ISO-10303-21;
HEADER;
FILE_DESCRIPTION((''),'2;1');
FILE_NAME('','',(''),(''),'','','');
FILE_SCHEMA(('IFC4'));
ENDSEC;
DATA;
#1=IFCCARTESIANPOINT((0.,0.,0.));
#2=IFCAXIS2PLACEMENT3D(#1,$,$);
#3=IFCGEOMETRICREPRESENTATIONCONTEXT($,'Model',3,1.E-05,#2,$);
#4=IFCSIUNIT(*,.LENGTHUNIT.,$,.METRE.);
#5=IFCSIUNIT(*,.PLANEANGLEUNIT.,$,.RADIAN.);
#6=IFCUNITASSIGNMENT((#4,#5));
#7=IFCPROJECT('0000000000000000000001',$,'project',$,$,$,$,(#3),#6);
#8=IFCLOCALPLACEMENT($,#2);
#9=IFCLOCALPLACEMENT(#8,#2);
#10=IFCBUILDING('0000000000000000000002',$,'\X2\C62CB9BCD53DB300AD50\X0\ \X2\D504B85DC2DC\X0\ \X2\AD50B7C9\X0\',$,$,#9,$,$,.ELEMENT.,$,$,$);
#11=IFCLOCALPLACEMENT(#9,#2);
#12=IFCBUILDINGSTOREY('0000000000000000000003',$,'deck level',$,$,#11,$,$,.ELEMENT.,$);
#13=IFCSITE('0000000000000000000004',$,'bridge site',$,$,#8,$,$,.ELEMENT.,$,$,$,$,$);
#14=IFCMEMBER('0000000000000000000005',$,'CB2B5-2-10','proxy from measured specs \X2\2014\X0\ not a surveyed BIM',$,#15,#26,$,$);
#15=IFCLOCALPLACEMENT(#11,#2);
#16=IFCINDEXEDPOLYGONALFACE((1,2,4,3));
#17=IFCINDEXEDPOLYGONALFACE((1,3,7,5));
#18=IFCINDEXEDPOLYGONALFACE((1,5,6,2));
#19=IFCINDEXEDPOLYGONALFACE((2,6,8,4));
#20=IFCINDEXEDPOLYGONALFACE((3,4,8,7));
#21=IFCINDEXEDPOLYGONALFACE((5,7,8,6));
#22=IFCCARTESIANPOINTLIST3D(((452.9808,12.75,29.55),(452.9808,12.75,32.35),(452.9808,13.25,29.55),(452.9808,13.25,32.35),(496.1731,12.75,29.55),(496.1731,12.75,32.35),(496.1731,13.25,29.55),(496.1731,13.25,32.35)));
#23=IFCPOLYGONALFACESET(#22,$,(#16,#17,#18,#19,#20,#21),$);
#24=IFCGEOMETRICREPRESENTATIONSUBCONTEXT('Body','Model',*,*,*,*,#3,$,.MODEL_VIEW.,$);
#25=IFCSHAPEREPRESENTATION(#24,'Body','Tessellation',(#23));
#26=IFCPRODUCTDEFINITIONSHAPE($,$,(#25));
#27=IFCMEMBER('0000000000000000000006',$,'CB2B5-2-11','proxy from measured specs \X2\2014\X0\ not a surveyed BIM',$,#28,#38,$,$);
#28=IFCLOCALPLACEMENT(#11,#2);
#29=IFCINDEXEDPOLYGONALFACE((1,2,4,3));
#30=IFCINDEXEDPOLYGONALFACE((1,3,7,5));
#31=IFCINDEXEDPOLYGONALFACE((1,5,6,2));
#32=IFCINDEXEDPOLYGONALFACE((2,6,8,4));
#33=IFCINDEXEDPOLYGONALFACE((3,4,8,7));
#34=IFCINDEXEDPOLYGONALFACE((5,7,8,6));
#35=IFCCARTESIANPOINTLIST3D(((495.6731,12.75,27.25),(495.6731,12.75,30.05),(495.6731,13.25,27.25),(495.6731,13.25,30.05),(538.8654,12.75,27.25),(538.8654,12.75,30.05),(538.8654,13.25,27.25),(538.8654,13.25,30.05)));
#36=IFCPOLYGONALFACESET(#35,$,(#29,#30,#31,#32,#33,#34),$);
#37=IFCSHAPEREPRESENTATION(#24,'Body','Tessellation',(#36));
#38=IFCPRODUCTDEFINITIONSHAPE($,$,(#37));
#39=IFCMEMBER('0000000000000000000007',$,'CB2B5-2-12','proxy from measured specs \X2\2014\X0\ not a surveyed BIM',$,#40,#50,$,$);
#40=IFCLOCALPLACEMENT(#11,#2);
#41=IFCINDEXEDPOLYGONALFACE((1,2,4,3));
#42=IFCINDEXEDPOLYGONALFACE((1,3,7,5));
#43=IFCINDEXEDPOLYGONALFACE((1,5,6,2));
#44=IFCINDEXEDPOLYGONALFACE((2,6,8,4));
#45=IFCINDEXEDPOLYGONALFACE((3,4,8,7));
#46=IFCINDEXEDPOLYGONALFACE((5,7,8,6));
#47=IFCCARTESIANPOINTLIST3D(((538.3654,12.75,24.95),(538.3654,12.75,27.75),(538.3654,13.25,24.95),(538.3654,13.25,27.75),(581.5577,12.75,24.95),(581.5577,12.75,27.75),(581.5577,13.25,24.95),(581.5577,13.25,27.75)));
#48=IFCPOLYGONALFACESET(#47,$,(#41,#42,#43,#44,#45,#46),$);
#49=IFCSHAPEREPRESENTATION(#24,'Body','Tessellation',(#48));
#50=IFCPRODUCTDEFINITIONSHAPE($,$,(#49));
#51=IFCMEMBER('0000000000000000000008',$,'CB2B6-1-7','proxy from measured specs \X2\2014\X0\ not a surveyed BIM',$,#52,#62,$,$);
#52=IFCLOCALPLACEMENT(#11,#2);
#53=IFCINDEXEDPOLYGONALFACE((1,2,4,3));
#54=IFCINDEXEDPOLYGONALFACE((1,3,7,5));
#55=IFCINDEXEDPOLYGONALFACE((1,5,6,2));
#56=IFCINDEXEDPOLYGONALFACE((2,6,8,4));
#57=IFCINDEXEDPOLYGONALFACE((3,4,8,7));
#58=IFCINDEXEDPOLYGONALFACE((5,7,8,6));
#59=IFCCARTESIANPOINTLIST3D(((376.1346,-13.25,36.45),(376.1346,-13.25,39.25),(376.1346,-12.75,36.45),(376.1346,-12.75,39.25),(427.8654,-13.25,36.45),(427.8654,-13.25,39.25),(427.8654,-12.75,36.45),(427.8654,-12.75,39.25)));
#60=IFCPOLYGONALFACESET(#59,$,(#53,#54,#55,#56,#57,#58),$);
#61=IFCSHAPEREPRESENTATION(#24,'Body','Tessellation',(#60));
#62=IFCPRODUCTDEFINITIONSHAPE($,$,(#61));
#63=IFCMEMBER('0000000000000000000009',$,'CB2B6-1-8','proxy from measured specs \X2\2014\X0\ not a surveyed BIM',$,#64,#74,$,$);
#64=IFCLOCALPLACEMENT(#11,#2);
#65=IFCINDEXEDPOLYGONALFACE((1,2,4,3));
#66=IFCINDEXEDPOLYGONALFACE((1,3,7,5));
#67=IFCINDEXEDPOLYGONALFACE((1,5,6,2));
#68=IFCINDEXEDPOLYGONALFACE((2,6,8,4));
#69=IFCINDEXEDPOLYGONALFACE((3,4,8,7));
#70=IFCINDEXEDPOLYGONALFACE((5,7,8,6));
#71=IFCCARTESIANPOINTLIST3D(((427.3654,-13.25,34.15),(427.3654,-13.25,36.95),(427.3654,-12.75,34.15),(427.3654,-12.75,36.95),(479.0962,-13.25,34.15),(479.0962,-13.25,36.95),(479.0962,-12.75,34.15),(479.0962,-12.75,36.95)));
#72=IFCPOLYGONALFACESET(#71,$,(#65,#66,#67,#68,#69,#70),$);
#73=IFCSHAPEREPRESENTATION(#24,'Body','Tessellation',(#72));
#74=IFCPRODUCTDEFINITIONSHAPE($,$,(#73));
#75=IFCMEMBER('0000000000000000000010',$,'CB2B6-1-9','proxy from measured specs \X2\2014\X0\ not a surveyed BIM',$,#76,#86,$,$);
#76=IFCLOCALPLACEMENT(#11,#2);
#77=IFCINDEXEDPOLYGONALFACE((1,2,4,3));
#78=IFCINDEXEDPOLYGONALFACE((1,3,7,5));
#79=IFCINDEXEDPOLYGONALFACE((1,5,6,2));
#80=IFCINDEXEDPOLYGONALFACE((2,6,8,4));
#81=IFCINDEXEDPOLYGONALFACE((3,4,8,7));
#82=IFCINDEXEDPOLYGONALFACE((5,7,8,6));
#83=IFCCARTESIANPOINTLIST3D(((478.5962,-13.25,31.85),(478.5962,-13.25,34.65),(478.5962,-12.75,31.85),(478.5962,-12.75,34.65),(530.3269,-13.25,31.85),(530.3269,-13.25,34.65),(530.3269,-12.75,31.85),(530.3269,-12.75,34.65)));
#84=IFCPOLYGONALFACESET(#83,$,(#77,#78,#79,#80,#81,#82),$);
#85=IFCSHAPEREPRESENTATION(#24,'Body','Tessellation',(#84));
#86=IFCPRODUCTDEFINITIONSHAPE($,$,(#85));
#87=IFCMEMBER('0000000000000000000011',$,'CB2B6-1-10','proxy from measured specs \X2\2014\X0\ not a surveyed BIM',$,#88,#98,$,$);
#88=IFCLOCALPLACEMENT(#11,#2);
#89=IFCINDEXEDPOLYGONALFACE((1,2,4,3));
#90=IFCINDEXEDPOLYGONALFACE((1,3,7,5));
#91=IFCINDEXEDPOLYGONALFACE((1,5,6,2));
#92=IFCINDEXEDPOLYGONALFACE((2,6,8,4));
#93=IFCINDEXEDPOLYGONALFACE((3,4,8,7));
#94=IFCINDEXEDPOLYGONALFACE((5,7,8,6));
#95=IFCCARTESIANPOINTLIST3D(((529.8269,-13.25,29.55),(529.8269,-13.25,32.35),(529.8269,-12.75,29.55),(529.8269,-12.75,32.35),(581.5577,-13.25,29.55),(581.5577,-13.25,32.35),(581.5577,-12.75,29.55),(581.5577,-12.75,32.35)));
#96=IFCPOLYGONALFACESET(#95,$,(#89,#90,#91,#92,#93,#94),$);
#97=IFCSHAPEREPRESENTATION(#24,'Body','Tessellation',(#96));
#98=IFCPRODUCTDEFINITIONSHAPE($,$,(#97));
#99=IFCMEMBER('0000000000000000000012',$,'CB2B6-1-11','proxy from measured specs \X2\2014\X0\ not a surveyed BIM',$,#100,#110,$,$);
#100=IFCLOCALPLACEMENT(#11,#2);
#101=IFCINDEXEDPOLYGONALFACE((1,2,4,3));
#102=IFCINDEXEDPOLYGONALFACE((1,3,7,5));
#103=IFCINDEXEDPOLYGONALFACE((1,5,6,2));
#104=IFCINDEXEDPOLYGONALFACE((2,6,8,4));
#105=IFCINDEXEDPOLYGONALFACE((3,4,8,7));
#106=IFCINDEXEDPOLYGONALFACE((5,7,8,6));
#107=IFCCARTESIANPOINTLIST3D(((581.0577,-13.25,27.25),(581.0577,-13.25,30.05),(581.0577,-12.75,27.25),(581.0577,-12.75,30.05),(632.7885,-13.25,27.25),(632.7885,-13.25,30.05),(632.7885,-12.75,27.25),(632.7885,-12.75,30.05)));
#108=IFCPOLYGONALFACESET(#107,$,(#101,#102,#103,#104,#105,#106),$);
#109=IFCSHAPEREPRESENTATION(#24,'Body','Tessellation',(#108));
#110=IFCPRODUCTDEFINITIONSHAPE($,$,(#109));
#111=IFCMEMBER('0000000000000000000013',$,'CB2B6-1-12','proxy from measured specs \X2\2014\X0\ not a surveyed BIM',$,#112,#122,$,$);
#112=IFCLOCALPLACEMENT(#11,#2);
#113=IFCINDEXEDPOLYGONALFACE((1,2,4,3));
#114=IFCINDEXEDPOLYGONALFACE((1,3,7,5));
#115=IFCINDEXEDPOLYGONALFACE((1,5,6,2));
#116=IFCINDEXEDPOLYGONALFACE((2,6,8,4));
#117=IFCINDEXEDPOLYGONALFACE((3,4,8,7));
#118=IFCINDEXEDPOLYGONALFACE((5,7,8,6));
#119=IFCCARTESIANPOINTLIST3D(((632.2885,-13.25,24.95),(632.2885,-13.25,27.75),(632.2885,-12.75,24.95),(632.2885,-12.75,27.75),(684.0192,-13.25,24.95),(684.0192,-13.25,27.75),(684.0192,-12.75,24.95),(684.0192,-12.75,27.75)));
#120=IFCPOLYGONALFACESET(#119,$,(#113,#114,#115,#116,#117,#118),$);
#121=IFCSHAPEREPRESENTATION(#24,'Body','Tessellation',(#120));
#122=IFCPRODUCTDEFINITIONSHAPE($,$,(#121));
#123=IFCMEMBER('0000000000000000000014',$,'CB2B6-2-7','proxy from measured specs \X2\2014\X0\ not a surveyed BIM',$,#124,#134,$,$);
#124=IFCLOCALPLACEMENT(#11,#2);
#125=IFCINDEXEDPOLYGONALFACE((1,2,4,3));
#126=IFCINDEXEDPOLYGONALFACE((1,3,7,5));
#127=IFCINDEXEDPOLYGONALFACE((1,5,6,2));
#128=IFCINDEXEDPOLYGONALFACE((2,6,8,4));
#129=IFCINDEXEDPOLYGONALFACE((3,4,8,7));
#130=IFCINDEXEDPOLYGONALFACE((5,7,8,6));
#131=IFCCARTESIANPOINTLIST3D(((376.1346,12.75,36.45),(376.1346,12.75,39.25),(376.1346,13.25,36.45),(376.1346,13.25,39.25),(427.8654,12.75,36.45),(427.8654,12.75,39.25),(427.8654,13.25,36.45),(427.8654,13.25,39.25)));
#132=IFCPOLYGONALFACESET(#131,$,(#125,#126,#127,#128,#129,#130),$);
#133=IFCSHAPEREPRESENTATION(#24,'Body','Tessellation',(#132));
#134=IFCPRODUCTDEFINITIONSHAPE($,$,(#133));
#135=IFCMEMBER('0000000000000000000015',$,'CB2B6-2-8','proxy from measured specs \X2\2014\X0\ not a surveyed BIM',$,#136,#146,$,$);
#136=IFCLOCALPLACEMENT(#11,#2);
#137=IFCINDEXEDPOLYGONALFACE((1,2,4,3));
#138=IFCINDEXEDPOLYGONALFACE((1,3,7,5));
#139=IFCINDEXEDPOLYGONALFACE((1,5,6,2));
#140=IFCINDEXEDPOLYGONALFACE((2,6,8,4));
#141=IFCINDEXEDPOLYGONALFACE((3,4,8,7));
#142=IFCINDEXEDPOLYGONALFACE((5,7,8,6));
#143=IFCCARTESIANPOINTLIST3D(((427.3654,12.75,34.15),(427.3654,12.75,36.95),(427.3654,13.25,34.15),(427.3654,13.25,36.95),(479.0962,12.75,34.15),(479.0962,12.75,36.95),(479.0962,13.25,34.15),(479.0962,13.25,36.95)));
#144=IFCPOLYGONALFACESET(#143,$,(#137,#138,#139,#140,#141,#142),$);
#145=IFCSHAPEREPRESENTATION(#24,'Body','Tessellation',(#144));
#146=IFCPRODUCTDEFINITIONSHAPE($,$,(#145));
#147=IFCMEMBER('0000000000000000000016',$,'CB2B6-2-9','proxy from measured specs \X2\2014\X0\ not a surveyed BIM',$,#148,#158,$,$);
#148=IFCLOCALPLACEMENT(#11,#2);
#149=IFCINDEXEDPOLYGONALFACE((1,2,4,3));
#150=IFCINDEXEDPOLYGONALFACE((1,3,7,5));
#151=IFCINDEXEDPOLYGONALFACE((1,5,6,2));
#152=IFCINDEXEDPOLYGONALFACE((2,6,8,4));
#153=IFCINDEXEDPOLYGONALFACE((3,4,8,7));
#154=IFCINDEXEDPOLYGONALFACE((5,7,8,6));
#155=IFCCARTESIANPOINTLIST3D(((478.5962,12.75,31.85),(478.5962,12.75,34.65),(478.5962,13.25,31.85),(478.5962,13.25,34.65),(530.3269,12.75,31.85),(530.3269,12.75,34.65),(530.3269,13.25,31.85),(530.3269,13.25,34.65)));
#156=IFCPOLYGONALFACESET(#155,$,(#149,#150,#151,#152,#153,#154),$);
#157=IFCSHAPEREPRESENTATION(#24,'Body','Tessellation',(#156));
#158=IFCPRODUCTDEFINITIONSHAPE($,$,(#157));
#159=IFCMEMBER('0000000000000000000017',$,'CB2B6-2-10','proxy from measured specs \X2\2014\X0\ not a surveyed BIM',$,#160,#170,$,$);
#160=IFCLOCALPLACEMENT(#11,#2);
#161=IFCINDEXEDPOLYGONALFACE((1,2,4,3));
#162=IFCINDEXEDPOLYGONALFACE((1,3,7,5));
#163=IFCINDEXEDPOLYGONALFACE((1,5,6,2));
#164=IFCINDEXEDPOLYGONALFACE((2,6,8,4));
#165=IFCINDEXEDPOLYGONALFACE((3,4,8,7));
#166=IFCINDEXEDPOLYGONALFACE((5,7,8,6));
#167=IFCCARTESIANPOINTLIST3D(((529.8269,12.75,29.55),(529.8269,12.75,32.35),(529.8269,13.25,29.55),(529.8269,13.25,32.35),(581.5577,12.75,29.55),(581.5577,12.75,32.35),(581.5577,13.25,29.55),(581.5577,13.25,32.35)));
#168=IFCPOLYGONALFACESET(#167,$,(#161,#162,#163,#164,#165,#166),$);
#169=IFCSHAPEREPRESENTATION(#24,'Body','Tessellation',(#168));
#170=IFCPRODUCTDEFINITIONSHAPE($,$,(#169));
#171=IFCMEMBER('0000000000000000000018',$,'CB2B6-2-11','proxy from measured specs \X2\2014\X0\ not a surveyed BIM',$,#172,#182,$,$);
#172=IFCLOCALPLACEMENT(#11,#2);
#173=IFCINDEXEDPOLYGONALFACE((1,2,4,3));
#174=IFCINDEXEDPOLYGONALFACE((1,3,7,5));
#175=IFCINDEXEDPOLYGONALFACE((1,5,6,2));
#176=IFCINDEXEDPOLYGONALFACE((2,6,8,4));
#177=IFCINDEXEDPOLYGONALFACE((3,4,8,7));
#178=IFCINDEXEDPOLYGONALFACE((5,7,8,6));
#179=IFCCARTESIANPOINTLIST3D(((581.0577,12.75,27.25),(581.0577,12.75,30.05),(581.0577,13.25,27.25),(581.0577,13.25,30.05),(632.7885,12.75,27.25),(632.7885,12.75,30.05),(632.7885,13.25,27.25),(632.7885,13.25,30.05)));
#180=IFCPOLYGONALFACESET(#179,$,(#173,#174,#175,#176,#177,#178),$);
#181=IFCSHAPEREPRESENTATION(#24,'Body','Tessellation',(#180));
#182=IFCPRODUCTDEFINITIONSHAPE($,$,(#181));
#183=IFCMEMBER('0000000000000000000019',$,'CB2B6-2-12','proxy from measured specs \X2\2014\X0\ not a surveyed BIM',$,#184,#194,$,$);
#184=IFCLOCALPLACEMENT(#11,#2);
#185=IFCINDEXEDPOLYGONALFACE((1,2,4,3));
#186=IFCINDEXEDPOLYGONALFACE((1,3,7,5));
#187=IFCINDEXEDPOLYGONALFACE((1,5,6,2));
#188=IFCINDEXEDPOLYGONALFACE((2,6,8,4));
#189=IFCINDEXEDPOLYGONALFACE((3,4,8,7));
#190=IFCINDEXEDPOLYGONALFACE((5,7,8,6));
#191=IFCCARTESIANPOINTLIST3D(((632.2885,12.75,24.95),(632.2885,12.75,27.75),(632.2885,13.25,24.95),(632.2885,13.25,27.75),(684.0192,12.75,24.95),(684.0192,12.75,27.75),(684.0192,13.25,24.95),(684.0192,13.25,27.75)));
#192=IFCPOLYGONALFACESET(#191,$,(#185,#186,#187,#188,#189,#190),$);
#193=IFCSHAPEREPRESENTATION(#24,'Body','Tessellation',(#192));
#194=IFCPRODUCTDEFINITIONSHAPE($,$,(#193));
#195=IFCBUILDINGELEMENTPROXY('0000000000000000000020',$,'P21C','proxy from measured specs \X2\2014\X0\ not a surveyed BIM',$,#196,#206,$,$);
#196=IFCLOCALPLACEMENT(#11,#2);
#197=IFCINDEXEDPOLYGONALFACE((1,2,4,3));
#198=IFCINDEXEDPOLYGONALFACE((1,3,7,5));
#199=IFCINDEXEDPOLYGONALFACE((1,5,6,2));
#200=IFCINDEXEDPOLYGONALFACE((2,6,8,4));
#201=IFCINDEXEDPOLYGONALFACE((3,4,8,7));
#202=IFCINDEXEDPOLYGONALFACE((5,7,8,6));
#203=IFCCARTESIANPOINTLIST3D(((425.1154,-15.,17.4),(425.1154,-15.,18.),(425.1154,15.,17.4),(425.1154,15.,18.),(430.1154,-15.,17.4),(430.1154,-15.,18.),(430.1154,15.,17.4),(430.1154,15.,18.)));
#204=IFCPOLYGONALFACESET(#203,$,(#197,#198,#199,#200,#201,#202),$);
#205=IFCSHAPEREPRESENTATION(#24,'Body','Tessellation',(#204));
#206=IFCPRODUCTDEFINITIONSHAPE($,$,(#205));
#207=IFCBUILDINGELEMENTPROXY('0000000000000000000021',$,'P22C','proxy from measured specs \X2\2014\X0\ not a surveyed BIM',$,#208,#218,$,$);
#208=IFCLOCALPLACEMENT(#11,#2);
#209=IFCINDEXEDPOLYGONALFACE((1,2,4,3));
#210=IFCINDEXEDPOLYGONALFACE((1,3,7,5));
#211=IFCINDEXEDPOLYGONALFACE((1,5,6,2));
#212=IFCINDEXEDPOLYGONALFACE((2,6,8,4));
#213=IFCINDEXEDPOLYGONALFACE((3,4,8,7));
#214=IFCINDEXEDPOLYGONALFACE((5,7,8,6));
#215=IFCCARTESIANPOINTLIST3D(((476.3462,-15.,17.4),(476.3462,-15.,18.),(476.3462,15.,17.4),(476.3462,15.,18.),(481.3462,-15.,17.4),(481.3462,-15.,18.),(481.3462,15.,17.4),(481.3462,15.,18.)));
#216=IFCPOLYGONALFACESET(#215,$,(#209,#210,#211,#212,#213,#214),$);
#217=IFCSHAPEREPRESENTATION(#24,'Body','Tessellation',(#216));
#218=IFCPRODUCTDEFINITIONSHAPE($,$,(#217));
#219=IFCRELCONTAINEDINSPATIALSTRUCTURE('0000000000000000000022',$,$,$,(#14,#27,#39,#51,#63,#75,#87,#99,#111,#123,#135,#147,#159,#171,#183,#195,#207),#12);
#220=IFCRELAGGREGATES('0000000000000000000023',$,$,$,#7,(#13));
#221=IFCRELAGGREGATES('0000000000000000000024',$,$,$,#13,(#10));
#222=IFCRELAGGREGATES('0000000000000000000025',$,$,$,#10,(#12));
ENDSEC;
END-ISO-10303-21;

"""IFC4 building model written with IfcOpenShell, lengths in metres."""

from ifc_helpers import new_model, si_unit, frame, origin, origin_2d, place, context, subcontext, project, spatial, rectangle, extrude, element, save


model = new_model("IFC4")

# Units and contexts
model_context = context("Model", 3, precision=1e-05, world=origin())
body_context = subcontext(model_context, "Body", "Model", "MODEL_VIEW")
ifc_project = project(units=[si_unit("LENGTHUNIT", "METRE"), si_unit("PLANEANGLEUNIT", "RADIAN")], contexts=[model_context])

# Site, building, storey
site_placement = place(None, origin())
site = spatial("IfcSite", under=ifc_project, at=site_placement, Name="bridge site", CompositionType="ELEMENT")
building_placement = place(site_placement, origin())
building = spatial("IfcBuilding", under=site, at=building_placement, Name="올림픽대교 프록시 교량", CompositionType="ELEMENT")
storey_placement = place(building_placement, origin())
storey = spatial("IfcBuildingStorey", under=building, at=storey_placement, Name="deck level", CompositionType="ELEMENT")

# Members
member_1_placement = place(storey_placement, frame((474.5769, 13.0, 29.55)))
element("IfcMember", 1, at=member_1_placement, inside=storey, Name="CB2B5-2-10", Description="proxy from measured specs — not a surveyed BIM", context=body_context, shape_type="SweptSolid", body=[
    extrude(rectangle(XDim=43.1923, YDim=0.5, at=origin_2d()), origin(), (0.0, 0.0, 1.0), 2.8),
])
member_2_placement = place(storey_placement, frame((517.2692, 13.0, 27.25)))
element("IfcMember", 2, at=member_2_placement, inside=storey, Name="CB2B5-2-11", Description="proxy from measured specs — not a surveyed BIM", context=body_context, shape_type="SweptSolid", body=[
    extrude(rectangle(XDim=43.1923, YDim=0.5, at=origin_2d()), origin(), (0.0, 0.0, 1.0), 2.8),
])
member_3_placement = place(storey_placement, frame((559.9615, 13.0, 24.95)))
element("IfcMember", 3, at=member_3_placement, inside=storey, Name="CB2B5-2-12", Description="proxy from measured specs — not a surveyed BIM", context=body_context, shape_type="SweptSolid", body=[
    extrude(rectangle(XDim=43.1923, YDim=0.5, at=origin_2d()), origin(), (0.0, 0.0, 1.0), 2.8),
])
member_4_placement = place(storey_placement, frame((402.0, -13.0, 36.45)))
element("IfcMember", 4, at=member_4_placement, inside=storey, Name="CB2B6-1-7", Description="proxy from measured specs — not a surveyed BIM", context=body_context, shape_type="SweptSolid", body=[
    extrude(rectangle(XDim=51.7308, YDim=0.5, at=origin_2d()), origin(), (0.0, 0.0, 1.0), 2.8),
])
member_5_placement = place(storey_placement, frame((453.2308, -13.0, 34.15)))
element("IfcMember", 5, at=member_5_placement, inside=storey, Name="CB2B6-1-8", Description="proxy from measured specs — not a surveyed BIM", context=body_context, shape_type="SweptSolid", body=[
    extrude(rectangle(XDim=51.7308, YDim=0.5, at=origin_2d()), origin(), (0.0, 0.0, 1.0), 2.8),
])
member_6_placement = place(storey_placement, frame((504.4615, -13.0, 31.85)))
element("IfcMember", 6, at=member_6_placement, inside=storey, Name="CB2B6-1-9", Description="proxy from measured specs — not a surveyed BIM", context=body_context, shape_type="SweptSolid", body=[
    extrude(rectangle(XDim=51.7308, YDim=0.5, at=origin_2d()), origin(), (0.0, 0.0, 1.0), 2.8),
])
member_7_placement = place(storey_placement, frame((555.6923, -13.0, 29.55)))
element("IfcMember", 7, at=member_7_placement, inside=storey, Name="CB2B6-1-10", Description="proxy from measured specs — not a surveyed BIM", context=body_context, shape_type="SweptSolid", body=[
    extrude(rectangle(XDim=51.7308, YDim=0.5, at=origin_2d()), origin(), (0.0, 0.0, 1.0), 2.8),
])
member_8_placement = place(storey_placement, frame((606.9231, -13.0, 27.25)))
element("IfcMember", 8, at=member_8_placement, inside=storey, Name="CB2B6-1-11", Description="proxy from measured specs — not a surveyed BIM", context=body_context, shape_type="SweptSolid", body=[
    extrude(rectangle(XDim=51.7308, YDim=0.5, at=origin_2d()), origin(), (0.0, 0.0, 1.0), 2.8),
])
member_9_placement = place(storey_placement, frame((658.1538, -13.0, 24.95)))
element("IfcMember", 9, at=member_9_placement, inside=storey, Name="CB2B6-1-12", Description="proxy from measured specs — not a surveyed BIM", context=body_context, shape_type="SweptSolid", body=[
    extrude(rectangle(XDim=51.7308, YDim=0.5, at=origin_2d()), origin(), (0.0, 0.0, 1.0), 2.8),
])
member_10_placement = place(storey_placement, frame((402.0, 13.0, 36.45)))
element("IfcMember", 10, at=member_10_placement, inside=storey, Name="CB2B6-2-7", Description="proxy from measured specs — not a surveyed BIM", context=body_context, shape_type="SweptSolid", body=[
    extrude(rectangle(XDim=51.7308, YDim=0.5, at=origin_2d()), origin(), (0.0, 0.0, 1.0), 2.8),
])
member_11_placement = place(storey_placement, frame((453.2308, 13.0, 34.15)))
element("IfcMember", 11, at=member_11_placement, inside=storey, Name="CB2B6-2-8", Description="proxy from measured specs — not a surveyed BIM", context=body_context, shape_type="SweptSolid", body=[
    extrude(rectangle(XDim=51.7308, YDim=0.5, at=origin_2d()), origin(), (0.0, 0.0, 1.0), 2.8),
])
member_12_placement = place(storey_placement, frame((504.4615, 13.0, 31.85)))
element("IfcMember", 12, at=member_12_placement, inside=storey, Name="CB2B6-2-9", Description="proxy from measured specs — not a surveyed BIM", context=body_context, shape_type="SweptSolid", body=[
    extrude(rectangle(XDim=51.7308, YDim=0.5, at=origin_2d()), origin(), (0.0, 0.0, 1.0), 2.8),
])
member_13_placement = place(storey_placement, frame((555.6923, 13.0, 29.55)))
element("IfcMember", 13, at=member_13_placement, inside=storey, Name="CB2B6-2-10", Description="proxy from measured specs — not a surveyed BIM", context=body_context, shape_type="SweptSolid", body=[
    extrude(rectangle(XDim=51.7308, YDim=0.5, at=origin_2d()), origin(), (0.0, 0.0, 1.0), 2.8),
])
member_14_placement = place(storey_placement, frame((606.9231, 13.0, 27.25)))
element("IfcMember", 14, at=member_14_placement, inside=storey, Name="CB2B6-2-11", Description="proxy from measured specs — not a surveyed BIM", context=body_context, shape_type="SweptSolid", body=[
    extrude(rectangle(XDim=51.7308, YDim=0.5, at=origin_2d()), origin(), (0.0, 0.0, 1.0), 2.8),
])
member_15_placement = place(storey_placement, frame((658.1538, 13.0, 24.95)))
element("IfcMember", 15, at=member_15_placement, inside=storey, Name="CB2B6-2-12", Description="proxy from measured specs — not a surveyed BIM", context=body_context, shape_type="SweptSolid", body=[
    extrude(rectangle(XDim=51.7308, YDim=0.5, at=origin_2d()), origin(), (0.0, 0.0, 1.0), 2.8),
])

# Building element proxies
for number, where, name in (
    (16, (427.6154, 0.0, 17.4), "P21C"),
    (17, (478.8462, 0.0, 17.4), "P22C"),
):
    element("IfcBuildingElementProxy", number, at=place(storey_placement, frame(where)), inside=storey, Name=name, Description="proxy from measured specs — not a surveyed BIM", context=body_context, shape_type="SweptSolid", body=[
        extrude(rectangle(XDim=5.0, YDim=30.0, at=origin_2d()), origin(), (0.0, 0.0, 1.0), 0.6),
    ])

save(model, "model.ifc")
